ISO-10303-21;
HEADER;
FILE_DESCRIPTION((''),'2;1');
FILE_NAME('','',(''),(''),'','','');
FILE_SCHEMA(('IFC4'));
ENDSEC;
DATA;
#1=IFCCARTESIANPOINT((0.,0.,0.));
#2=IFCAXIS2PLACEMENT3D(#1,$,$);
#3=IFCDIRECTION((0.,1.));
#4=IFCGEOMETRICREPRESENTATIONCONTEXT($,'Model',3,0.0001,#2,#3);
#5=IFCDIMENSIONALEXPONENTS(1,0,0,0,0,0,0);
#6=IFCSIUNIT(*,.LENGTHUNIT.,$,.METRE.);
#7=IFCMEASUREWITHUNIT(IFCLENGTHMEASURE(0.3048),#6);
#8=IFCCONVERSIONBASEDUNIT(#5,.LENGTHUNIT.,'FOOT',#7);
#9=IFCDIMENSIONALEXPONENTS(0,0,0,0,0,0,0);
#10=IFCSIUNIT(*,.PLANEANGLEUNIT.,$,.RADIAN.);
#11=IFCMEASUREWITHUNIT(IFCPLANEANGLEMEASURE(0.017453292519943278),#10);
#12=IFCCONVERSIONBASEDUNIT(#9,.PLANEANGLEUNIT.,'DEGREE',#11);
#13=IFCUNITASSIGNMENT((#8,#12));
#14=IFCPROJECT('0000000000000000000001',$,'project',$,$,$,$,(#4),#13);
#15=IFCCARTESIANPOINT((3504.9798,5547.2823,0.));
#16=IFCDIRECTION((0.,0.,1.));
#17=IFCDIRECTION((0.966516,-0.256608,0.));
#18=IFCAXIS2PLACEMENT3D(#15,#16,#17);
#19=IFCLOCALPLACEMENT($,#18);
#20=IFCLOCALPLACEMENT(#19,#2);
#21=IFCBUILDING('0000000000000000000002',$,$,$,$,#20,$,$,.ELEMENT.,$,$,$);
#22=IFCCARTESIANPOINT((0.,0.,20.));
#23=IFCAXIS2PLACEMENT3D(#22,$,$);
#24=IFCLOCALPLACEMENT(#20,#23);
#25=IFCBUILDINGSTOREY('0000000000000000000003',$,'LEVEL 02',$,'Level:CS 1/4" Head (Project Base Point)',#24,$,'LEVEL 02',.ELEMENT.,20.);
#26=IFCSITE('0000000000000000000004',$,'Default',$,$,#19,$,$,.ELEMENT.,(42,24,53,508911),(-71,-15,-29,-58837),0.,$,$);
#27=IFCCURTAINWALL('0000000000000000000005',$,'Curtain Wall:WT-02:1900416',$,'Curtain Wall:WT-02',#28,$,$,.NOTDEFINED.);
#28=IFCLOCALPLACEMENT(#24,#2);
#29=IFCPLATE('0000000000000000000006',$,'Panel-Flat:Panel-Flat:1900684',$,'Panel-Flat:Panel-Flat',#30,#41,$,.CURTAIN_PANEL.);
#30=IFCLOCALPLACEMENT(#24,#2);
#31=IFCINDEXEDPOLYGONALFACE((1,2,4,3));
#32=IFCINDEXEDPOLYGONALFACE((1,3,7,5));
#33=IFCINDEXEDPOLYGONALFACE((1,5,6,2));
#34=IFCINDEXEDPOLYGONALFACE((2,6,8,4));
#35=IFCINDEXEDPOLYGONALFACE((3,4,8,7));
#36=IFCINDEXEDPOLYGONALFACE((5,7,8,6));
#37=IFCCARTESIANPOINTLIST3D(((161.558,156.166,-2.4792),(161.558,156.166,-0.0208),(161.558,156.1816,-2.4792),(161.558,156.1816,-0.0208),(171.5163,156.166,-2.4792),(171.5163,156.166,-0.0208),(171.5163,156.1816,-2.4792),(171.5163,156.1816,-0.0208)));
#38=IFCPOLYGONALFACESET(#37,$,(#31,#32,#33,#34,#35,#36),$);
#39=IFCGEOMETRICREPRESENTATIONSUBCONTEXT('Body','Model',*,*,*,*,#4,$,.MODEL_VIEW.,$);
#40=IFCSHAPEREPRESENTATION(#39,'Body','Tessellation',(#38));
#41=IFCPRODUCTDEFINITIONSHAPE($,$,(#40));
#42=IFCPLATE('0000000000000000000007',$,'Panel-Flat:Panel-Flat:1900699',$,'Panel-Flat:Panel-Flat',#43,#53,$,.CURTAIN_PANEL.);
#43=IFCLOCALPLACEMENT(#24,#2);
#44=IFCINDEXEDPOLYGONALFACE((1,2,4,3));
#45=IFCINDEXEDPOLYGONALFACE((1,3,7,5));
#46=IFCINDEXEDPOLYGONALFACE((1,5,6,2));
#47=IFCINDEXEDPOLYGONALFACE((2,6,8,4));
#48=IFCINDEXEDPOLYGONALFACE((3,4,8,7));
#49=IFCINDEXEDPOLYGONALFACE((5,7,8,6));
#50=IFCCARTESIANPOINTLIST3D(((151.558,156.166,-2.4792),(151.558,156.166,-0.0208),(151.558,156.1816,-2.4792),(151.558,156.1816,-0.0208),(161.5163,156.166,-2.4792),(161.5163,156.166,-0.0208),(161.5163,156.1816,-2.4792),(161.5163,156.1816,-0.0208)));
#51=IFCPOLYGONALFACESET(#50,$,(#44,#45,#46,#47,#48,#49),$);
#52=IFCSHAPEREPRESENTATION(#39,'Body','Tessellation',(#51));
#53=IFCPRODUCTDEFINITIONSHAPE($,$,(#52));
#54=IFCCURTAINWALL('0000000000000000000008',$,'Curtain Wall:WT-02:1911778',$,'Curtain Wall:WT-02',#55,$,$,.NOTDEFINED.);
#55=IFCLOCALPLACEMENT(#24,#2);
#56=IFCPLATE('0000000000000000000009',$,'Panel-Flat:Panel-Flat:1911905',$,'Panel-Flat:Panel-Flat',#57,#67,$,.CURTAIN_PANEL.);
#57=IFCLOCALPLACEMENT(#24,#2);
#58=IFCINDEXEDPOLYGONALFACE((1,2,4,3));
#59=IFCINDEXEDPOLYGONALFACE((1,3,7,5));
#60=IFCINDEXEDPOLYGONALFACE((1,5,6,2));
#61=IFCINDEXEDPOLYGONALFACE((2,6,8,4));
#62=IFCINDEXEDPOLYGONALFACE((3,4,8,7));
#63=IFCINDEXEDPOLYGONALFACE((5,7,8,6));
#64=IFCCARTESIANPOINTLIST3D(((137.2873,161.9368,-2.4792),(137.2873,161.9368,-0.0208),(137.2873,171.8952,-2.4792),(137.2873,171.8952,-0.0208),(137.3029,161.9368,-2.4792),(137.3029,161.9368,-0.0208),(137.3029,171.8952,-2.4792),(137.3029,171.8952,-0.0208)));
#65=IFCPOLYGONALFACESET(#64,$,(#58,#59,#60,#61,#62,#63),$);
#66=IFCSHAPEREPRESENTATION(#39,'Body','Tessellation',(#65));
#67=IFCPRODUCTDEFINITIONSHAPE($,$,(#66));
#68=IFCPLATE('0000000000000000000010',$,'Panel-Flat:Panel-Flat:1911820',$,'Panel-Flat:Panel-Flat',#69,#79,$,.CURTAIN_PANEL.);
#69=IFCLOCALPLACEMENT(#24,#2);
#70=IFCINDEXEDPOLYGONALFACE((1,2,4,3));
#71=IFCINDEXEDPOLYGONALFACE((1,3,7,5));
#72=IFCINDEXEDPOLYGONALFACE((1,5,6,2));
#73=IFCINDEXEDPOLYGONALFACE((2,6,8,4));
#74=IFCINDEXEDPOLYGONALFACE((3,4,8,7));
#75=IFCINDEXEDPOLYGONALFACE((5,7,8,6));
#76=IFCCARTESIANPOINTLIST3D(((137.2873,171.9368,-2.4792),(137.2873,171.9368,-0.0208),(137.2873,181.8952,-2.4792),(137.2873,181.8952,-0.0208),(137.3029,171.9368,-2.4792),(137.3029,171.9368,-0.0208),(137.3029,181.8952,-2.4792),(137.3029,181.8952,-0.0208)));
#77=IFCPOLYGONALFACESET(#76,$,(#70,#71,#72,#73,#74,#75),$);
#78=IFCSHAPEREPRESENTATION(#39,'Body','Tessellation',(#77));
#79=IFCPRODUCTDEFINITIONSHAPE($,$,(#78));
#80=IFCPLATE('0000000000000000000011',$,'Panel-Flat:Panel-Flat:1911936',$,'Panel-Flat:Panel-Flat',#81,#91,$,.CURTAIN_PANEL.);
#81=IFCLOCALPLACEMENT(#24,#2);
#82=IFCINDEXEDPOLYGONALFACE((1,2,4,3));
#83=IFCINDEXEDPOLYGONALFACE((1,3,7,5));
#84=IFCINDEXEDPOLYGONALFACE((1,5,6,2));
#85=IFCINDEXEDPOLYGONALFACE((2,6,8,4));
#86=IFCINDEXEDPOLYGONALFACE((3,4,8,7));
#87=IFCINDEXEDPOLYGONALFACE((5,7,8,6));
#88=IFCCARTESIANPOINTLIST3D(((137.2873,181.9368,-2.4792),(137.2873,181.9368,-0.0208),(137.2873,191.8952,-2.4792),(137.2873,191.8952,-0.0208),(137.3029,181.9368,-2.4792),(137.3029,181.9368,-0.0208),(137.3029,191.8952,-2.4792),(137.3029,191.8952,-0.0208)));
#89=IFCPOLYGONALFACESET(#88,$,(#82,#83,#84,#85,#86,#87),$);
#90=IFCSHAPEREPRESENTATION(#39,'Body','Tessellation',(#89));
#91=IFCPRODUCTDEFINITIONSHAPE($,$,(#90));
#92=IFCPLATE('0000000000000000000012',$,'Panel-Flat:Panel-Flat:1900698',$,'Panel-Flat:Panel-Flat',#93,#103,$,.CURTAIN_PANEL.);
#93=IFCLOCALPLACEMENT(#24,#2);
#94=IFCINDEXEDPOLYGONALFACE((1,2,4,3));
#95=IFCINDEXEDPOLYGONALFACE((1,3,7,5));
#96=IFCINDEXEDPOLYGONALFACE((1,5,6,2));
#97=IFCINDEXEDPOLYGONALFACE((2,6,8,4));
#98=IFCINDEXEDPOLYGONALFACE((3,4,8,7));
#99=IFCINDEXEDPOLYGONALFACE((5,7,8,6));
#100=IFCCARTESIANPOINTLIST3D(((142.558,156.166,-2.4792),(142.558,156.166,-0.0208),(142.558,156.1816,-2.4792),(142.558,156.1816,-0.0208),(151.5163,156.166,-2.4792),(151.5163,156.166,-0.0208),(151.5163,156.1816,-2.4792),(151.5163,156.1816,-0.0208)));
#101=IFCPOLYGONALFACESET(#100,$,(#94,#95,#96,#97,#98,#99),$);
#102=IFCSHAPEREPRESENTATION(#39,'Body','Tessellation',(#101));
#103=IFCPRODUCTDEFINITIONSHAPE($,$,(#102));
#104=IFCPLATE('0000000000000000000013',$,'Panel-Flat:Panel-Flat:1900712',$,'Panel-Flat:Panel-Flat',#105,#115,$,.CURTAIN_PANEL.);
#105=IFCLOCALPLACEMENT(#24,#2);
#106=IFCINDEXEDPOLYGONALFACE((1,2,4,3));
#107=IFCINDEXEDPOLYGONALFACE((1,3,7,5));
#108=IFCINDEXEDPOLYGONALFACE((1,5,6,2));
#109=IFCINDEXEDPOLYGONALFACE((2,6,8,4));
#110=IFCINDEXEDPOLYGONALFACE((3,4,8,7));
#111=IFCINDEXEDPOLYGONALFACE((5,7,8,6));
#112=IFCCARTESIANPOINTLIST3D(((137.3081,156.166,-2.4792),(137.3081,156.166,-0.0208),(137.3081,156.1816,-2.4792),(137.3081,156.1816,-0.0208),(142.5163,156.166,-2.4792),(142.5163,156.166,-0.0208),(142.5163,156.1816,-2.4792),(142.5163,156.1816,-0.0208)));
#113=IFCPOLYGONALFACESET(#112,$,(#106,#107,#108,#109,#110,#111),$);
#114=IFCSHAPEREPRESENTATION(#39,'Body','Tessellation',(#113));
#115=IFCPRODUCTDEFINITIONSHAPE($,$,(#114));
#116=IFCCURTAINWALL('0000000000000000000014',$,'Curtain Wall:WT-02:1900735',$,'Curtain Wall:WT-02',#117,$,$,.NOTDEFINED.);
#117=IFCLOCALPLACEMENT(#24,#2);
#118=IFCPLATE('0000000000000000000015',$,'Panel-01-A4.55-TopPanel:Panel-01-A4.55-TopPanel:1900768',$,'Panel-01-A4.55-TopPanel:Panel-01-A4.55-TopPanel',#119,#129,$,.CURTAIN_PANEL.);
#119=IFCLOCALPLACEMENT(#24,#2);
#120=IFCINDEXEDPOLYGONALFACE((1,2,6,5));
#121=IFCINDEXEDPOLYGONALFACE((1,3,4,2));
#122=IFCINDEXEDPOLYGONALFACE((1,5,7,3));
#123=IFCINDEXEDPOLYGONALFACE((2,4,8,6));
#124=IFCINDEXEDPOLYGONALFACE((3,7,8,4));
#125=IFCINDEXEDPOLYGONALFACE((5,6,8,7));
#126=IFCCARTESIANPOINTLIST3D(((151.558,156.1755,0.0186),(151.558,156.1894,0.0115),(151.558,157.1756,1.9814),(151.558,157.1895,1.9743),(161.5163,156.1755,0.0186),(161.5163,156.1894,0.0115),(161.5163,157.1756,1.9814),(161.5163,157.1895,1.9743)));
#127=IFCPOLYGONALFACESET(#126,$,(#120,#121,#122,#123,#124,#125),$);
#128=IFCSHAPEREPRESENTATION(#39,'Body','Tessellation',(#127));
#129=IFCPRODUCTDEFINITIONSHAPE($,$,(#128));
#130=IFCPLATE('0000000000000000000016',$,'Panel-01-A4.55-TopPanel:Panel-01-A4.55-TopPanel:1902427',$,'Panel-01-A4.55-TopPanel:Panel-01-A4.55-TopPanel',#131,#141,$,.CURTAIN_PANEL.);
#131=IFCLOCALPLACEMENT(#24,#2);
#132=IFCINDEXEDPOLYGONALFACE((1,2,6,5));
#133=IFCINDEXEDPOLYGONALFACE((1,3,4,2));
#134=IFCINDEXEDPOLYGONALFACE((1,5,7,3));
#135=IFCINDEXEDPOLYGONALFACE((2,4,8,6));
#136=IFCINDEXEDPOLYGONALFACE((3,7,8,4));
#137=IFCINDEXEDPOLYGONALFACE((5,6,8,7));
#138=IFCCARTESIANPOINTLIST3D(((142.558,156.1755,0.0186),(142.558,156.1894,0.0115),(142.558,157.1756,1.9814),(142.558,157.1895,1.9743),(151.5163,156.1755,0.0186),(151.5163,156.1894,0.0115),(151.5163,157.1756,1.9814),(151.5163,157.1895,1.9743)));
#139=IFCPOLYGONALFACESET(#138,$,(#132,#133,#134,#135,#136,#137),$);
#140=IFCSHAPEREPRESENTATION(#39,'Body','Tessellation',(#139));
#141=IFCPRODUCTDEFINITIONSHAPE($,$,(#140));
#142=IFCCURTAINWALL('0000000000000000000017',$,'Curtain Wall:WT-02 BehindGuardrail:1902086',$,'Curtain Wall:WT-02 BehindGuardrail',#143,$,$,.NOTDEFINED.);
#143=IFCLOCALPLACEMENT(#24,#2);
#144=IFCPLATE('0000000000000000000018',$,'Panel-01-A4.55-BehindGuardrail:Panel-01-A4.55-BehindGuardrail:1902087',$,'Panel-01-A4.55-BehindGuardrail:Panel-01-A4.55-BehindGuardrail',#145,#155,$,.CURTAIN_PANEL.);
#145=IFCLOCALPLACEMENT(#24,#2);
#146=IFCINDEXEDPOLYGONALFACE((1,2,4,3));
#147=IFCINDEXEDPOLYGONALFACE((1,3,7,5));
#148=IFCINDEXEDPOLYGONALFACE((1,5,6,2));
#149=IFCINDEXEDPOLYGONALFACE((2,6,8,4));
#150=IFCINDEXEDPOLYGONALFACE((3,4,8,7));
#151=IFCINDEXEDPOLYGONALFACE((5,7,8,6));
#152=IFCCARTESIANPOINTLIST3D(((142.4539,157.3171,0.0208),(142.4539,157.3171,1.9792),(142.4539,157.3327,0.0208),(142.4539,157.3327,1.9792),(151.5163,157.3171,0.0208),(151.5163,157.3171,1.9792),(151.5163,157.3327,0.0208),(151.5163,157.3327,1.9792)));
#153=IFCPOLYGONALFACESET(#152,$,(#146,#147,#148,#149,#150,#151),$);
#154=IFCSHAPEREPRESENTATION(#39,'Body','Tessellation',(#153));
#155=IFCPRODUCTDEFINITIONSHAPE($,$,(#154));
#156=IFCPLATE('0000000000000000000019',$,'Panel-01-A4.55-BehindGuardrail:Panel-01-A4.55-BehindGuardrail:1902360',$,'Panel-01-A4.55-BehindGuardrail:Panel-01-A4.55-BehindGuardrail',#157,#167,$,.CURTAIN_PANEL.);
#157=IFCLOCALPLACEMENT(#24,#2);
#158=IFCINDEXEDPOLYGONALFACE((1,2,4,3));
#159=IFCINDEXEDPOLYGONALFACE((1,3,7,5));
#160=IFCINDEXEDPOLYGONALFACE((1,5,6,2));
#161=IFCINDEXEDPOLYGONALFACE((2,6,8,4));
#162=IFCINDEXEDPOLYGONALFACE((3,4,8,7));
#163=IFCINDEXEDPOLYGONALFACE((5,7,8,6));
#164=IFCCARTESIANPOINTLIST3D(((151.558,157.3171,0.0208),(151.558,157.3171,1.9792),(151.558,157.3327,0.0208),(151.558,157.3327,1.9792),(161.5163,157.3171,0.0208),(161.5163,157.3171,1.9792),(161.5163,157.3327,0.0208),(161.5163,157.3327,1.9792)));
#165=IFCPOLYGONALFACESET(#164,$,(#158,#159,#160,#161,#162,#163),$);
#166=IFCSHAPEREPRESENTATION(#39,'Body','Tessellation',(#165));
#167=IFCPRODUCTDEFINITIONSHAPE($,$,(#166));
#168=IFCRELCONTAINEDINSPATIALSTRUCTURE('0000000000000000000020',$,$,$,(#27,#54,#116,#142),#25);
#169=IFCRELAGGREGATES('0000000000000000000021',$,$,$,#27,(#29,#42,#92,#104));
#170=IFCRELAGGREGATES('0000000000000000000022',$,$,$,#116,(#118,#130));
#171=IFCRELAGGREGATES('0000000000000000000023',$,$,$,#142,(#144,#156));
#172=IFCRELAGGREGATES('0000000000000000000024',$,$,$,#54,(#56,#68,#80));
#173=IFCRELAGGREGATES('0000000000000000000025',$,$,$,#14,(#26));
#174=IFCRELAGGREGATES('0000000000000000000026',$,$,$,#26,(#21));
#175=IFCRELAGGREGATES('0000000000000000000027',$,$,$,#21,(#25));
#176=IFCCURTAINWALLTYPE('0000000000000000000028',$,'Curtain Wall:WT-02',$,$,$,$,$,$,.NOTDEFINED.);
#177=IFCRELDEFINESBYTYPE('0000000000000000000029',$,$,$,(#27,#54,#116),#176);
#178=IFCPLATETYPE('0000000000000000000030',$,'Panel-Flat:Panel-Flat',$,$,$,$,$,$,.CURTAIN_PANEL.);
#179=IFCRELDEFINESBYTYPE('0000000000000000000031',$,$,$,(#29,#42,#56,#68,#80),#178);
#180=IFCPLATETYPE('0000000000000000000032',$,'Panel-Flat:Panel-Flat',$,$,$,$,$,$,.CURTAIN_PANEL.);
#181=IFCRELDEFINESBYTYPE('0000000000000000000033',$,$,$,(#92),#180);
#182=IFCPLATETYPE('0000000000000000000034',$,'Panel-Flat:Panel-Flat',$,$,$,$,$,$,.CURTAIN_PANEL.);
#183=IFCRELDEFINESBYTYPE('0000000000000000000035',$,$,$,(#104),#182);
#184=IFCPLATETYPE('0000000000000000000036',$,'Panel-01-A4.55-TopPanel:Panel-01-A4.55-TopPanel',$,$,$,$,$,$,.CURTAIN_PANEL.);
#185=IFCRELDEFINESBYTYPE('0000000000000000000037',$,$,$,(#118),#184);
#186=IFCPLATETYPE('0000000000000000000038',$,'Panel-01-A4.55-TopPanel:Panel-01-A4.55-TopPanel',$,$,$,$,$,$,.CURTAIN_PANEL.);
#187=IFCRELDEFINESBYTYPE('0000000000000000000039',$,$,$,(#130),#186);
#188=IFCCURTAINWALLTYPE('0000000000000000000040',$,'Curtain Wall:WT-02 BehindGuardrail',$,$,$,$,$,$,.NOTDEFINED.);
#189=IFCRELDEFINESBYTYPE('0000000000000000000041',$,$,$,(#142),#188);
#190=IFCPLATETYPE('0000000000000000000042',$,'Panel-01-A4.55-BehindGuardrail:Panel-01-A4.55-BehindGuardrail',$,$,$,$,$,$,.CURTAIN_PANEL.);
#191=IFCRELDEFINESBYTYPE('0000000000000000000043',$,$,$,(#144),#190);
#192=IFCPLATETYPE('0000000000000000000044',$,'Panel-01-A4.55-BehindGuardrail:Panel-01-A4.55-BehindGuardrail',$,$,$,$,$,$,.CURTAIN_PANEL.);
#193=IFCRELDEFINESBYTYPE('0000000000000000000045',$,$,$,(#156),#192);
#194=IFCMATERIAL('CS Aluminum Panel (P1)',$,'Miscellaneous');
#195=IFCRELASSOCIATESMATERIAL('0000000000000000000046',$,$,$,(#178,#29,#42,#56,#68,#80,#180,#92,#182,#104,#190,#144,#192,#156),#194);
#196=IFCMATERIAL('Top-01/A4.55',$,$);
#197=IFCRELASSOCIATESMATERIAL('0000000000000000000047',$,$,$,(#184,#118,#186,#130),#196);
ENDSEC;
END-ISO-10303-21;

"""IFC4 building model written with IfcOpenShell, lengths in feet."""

from ifc_helpers import new_model, entity, si_unit, converted_unit, direction, frame, origin, place, context, subcontext, project, spatial, indexed_curve, outline, extrude, source, transform, mapped, material, type_object, type_shapes, element, aggregate, save


model = new_model("IFC4")

# Units and contexts
model_context = context("Model", 3, precision=0.0001, world=origin(), true_north=direction((0.0, 1.0)))
body_context = subcontext(model_context, "Body", "Model", "MODEL_VIEW")
ifc_project = project(units=[converted_unit("LENGTHUNIT", "FOOT", entity("IfcLengthMeasure", 0.3048), si_unit("LENGTHUNIT", "METRE"), dimensions=[1, 0, 0, 0, 0, 0, 0]), converted_unit("PLANEANGLEUNIT", "DEGREE", entity("IfcPlaneAngleMeasure", 0.017453292519943278), si_unit("PLANEANGLEUNIT", "RADIAN"), dimensions=[0, 0, 0, 0, 0, 0, 0])], contexts=[model_context])

# Site, building, storey
site_placement = place(None, frame((3504.9798, 5547.2823, 0.0), z_axis=(0.0, 0.0, 1.0), x_axis=(0.966516, -0.256608, 0.0)))
site = spatial("IfcSite", under=ifc_project, at=site_placement, Name="Default", CompositionType="ELEMENT", RefLatitude=(42, 24, 53, 508911), RefLongitude=(-71, -15, -29, -58837), RefElevation=0.0)
building_placement = place(site_placement, origin())
building = spatial("IfcBuilding", under=site, at=building_placement, CompositionType="ELEMENT")
storey_placement = place(building_placement, frame((0.0, 0.0, 20.0)))
storey = spatial("IfcBuildingStorey", under=building, at=storey_placement, Name="LEVEL 02", ObjectType="Level:CS 1/4\" Head (Project Base Point)", LongName="LEVEL 02", CompositionType="ELEMENT", Elevation=20.0)

# Curtain walls, plates
curtain_wall_type_1 = type_object("IfcCurtainWallType", Name="Curtain Wall:WT-02", PredefinedType="NOTDEFINED")
curtain_wall_1_placement = place(storey_placement, frame((0.0, 0.0, -20.0)))
curtain_wall_1 = element("IfcCurtainWall", 1, at=curtain_wall_1_placement, inside=storey, type_object=curtain_wall_type_1, Name="Curtain Wall:WT-02:1900416", ObjectType="Curtain Wall:WT-02", PredefinedType="NOTDEFINED")
ifc_material_1 = material(Name="CS Aluminum Panel (P1)", Category="Miscellaneous")
plate_type_1 = type_object("IfcPlateType", Name="Panel-Flat:Panel-Flat", PredefinedType="CURTAIN_PANEL", material=ifc_material_1)
shared_shape_1 = source(origin(), body_context, "Body", "SweptSolid", [
    extrude(outline(indexed_curve([(-0.0078, -4.9792), (0.0078, -4.9792), (0.0078, 4.9792), (-0.0078, 4.9792), (-0.0078, -4.9792)], self_intersect=False)), frame((0.0, -0.0078, 0.0208), z_axis=(0.0, 0.0, 1.0), x_axis=(0.0, -1.0, 0.0)), (0.0, 0.0, 1.0), 2.4583),
])
type_shapes(plate_type_1, [shared_shape_1])
plate_1_placement = place(curtain_wall_1_placement, frame((166.5372, 156.166, 17.5), z_axis=(0.0, 0.0, 1.0), x_axis=(-1.0, 0.0, 0.0)))
plate_1 = element("IfcPlate", 2, at=plate_1_placement, type_object=plate_type_1, material=ifc_material_1, Name="Panel-Flat:Panel-Flat:1900684", ObjectType="Panel-Flat:Panel-Flat", PredefinedType="CURTAIN_PANEL", context=body_context, shape_type="MappedRepresentation", body=[
    mapped(shared_shape_1, transform((0.0, 0.0, 0.0), scale=1.0)),
])
plate_2_placement = place(curtain_wall_1_placement, frame((156.5372, 156.166, 17.5), z_axis=(0.0, 0.0, 1.0), x_axis=(-1.0, 0.0, 0.0)))
plate_2 = element("IfcPlate", 3, at=plate_2_placement, type_object=plate_type_1, material=ifc_material_1, Name="Panel-Flat:Panel-Flat:1900699", ObjectType="Panel-Flat:Panel-Flat", PredefinedType="CURTAIN_PANEL", context=body_context, shape_type="MappedRepresentation", body=[
    mapped(shared_shape_1, transform((0.0, 0.0, 0.0), scale=1.0)),
])
curtain_wall_2_placement = place(storey_placement, frame((0.0, 0.0, -20.0)))
curtain_wall_2 = element("IfcCurtainWall", 4, at=curtain_wall_2_placement, inside=storey, type_object=curtain_wall_type_1, Name="Curtain Wall:WT-02:1911778", ObjectType="Curtain Wall:WT-02", PredefinedType="NOTDEFINED")
plate_3_placement = place(curtain_wall_2_placement, frame((137.2873, 166.916, 17.5), z_axis=(0.0, 0.0, 1.0), x_axis=(0.0, 1.0, 0.0)))
plate_3 = element("IfcPlate", 5, at=plate_3_placement, type_object=plate_type_1, material=ifc_material_1, Name="Panel-Flat:Panel-Flat:1911905", ObjectType="Panel-Flat:Panel-Flat", PredefinedType="CURTAIN_PANEL", context=body_context, shape_type="MappedRepresentation", body=[
    mapped(shared_shape_1, transform((0.0, 0.0, 0.0), scale=1.0)),
])
plate_4_placement = place(curtain_wall_2_placement, frame((137.2873, 176.916, 17.5), z_axis=(0.0, 0.0, 1.0), x_axis=(0.0, 1.0, 0.0)))
plate_4 = element("IfcPlate", 6, at=plate_4_placement, type_object=plate_type_1, material=ifc_material_1, Name="Panel-Flat:Panel-Flat:1911820", ObjectType="Panel-Flat:Panel-Flat", PredefinedType="CURTAIN_PANEL", context=body_context, shape_type="MappedRepresentation", body=[
    mapped(shared_shape_1, transform((0.0, 0.0, 0.0), scale=1.0)),
])
plate_5_placement = place(curtain_wall_2_placement, frame((137.2873, 186.916, 17.5), z_axis=(0.0, 0.0, 1.0), x_axis=(0.0, 1.0, 0.0)))
plate_5 = element("IfcPlate", 7, at=plate_5_placement, type_object=plate_type_1, material=ifc_material_1, Name="Panel-Flat:Panel-Flat:1911936", ObjectType="Panel-Flat:Panel-Flat", PredefinedType="CURTAIN_PANEL", context=body_context, shape_type="MappedRepresentation", body=[
    mapped(shared_shape_1, transform((0.0, 0.0, 0.0), scale=1.0)),
])

# Plates
plate_type_2 = type_object("IfcPlateType", Name="Panel-Flat:Panel-Flat", PredefinedType="CURTAIN_PANEL", material=ifc_material_1)
shared_shape_2 = source(origin(), body_context, "Body", "SweptSolid", [
    extrude(outline(indexed_curve([(-0.0078, -4.4792), (0.0078, -4.4792), (0.0078, 4.4792), (-0.0078, 4.4792), (-0.0078, -4.4792)], self_intersect=False)), frame((0.0, -0.0078, 0.0208), z_axis=(0.0, 0.0, 1.0), x_axis=(0.0, -1.0, 0.0)), (0.0, 0.0, 1.0), 2.4583),
])
type_shapes(plate_type_2, [shared_shape_2])
plate_6_placement = place(curtain_wall_1_placement, frame((147.0372, 156.166, 17.5), z_axis=(0.0, 0.0, 1.0), x_axis=(-1.0, 0.0, 0.0)))
plate_6 = element("IfcPlate", 8, at=plate_6_placement, type_object=plate_type_2, material=ifc_material_1, Name="Panel-Flat:Panel-Flat:1900698", ObjectType="Panel-Flat:Panel-Flat", PredefinedType="CURTAIN_PANEL", context=body_context, shape_type="MappedRepresentation", body=[
    mapped(shared_shape_2, transform((0.0, 0.0, 0.0), scale=1.0)),
])
plate_type_3 = type_object("IfcPlateType", Name="Panel-Flat:Panel-Flat", PredefinedType="CURTAIN_PANEL", material=ifc_material_1)
shared_shape_3 = source(origin(), body_context, "Body", "SweptSolid", [
    extrude(outline(indexed_curve([(-0.0078, -2.6041), (0.0078, -2.6041), (0.0078, 2.6041), (-0.0078, 2.6041), (-0.0078, -2.6041)], self_intersect=False)), frame((0.0, -0.0078, 0.0208), z_axis=(0.0, 0.0, 1.0), x_axis=(0.0, -1.0, 0.0)), (0.0, 0.0, 1.0), 2.4583),
])
type_shapes(plate_type_3, [shared_shape_3])
plate_7_placement = place(curtain_wall_1_placement, frame((139.9122, 156.166, 17.5), z_axis=(0.0, 0.0, 1.0), x_axis=(-1.0, 0.0, 0.0)))
plate_7 = element("IfcPlate", 9, at=plate_7_placement, type_object=plate_type_3, material=ifc_material_1, Name="Panel-Flat:Panel-Flat:1900712", ObjectType="Panel-Flat:Panel-Flat", PredefinedType="CURTAIN_PANEL", context=body_context, shape_type="MappedRepresentation", body=[
    mapped(shared_shape_3, transform((0.0, 0.0, 0.0), scale=1.0)),
])
aggregate(curtain_wall_1, [plate_1, plate_2, plate_6, plate_7])

# Curtain walls, plates
curtain_wall_3_placement = place(storey_placement, frame((0.0, 0.0, -20.0)))
curtain_wall_3 = element("IfcCurtainWall", 10, at=curtain_wall_3_placement, inside=storey, type_object=curtain_wall_type_1, Name="Curtain Wall:WT-02:1900735", ObjectType="Curtain Wall:WT-02", PredefinedType="NOTDEFINED")
ifc_material_2 = material(Name="Top-01/A4.55")
plate_type_4 = type_object("IfcPlateType", Name="Panel-01-A4.55-TopPanel:Panel-01-A4.55-TopPanel", PredefinedType="CURTAIN_PANEL", material=ifc_material_2)
shared_shape_4 = source(origin(), body_context, "Body", "SweptSolid", [
    extrude(outline(indexed_curve([(-0.0078, -4.9792), (0.0078, -4.9792), (0.0078, 4.9792), (-0.0078, 4.9792), (-0.0078, -4.9792)], self_intersect=False)), frame((0.0, -0.0078, 0.0208), z_axis=(0.0, 0.0, 1.0), x_axis=(0.0, -1.0, 0.0)), (0.0, 0.0, 1.0), 2.203),
])
type_shapes(plate_type_4, [shared_shape_4])
plate_8_placement = place(curtain_wall_3_placement, frame((156.5372, 156.166, 20.0), z_axis=(0.0, 0.45399, 0.891007), x_axis=(-1.0, 0.0, 0.0)))
plate_8 = element("IfcPlate", 11, at=plate_8_placement, type_object=plate_type_4, material=ifc_material_2, Name="Panel-01-A4.55-TopPanel:Panel-01-A4.55-TopPanel:1900768", ObjectType="Panel-01-A4.55-TopPanel:Panel-01-A4.55-TopPanel", PredefinedType="CURTAIN_PANEL", context=body_context, shape_type="MappedRepresentation", body=[
    mapped(shared_shape_4, transform((0.0, 0.0, 0.0), scale=1.0)),
])
plate_type_5 = type_object("IfcPlateType", Name="Panel-01-A4.55-TopPanel:Panel-01-A4.55-TopPanel", PredefinedType="CURTAIN_PANEL", material=ifc_material_2)
shared_shape_5 = source(origin(), body_context, "Body", "SweptSolid", [
    extrude(outline(indexed_curve([(-0.0078, -4.4792), (0.0078, -4.4792), (0.0078, 4.4792), (-0.0078, 4.4792), (-0.0078, -4.4792)], self_intersect=False)), frame((0.0, -0.0078, 0.0208), z_axis=(0.0, 0.0, 1.0), x_axis=(0.0, -1.0, 0.0)), (0.0, 0.0, 1.0), 2.203),
])
type_shapes(plate_type_5, [shared_shape_5])
plate_9_placement = place(curtain_wall_3_placement, frame((147.0372, 156.166, 20.0), z_axis=(0.0, 0.45399, 0.891007), x_axis=(-1.0, 0.0, 0.0)))
plate_9 = element("IfcPlate", 12, at=plate_9_placement, type_object=plate_type_5, material=ifc_material_2, Name="Panel-01-A4.55-TopPanel:Panel-01-A4.55-TopPanel:1902427", ObjectType="Panel-01-A4.55-TopPanel:Panel-01-A4.55-TopPanel", PredefinedType="CURTAIN_PANEL", context=body_context, shape_type="MappedRepresentation", body=[
    mapped(shared_shape_5, transform((0.0, 0.0, 0.0), scale=1.0)),
])
aggregate(curtain_wall_3, [plate_8, plate_9])
curtain_wall_type_2 = type_object("IfcCurtainWallType", Name="Curtain Wall:WT-02 BehindGuardrail", PredefinedType="NOTDEFINED")
curtain_wall_4_placement = place(storey_placement, frame((0.0, 0.0, -20.0)))
curtain_wall_4 = element("IfcCurtainWall", 13, at=curtain_wall_4_placement, inside=storey, type_object=curtain_wall_type_2, Name="Curtain Wall:WT-02 BehindGuardrail:1902086", ObjectType="Curtain Wall:WT-02 BehindGuardrail", PredefinedType="NOTDEFINED")
plate_type_6 = type_object("IfcPlateType", Name="Panel-01-A4.55-BehindGuardrail:Panel-01-A4.55-BehindGuardrail", PredefinedType="CURTAIN_PANEL", material=ifc_material_1)
shared_shape_6 = source(origin(), body_context, "Body", "SweptSolid", [
    extrude(outline(indexed_curve([(-0.0078, -4.5312), (0.0078, -4.5312), (0.0078, 4.5312), (-0.0078, 4.5312), (-0.0078, -4.5312)], self_intersect=False)), frame((0.0, -0.0078, 0.0208), z_axis=(0.0, 0.0, 1.0), x_axis=(0.0, -1.0, 0.0)), (0.0, 0.0, 1.0), 1.9583),
])
type_shapes(plate_type_6, [shared_shape_6])
plate_10_placement = place(curtain_wall_4_placement, frame((146.9851, 157.3327, 20.0)))
plate_10 = element("IfcPlate", 14, at=plate_10_placement, type_object=plate_type_6, material=ifc_material_1, Name="Panel-01-A4.55-BehindGuardrail:Panel-01-A4.55-BehindGuardrail:1902087", ObjectType="Panel-01-A4.55-BehindGuardrail:Panel-01-A4.55-BehindGuardrail", PredefinedType="CURTAIN_PANEL", context=body_context, shape_type="MappedRepresentation", body=[
    mapped(shared_shape_6, transform((0.0, 0.0, 0.0), scale=1.0)),
])
plate_type_7 = type_object("IfcPlateType", Name="Panel-01-A4.55-BehindGuardrail:Panel-01-A4.55-BehindGuardrail", PredefinedType="CURTAIN_PANEL", material=ifc_material_1)
shared_shape_7 = source(origin(), body_context, "Body", "SweptSolid", [
    extrude(outline(indexed_curve([(-0.0078, -4.9792), (0.0078, -4.9792), (0.0078, 4.9792), (-0.0078, 4.9792), (-0.0078, -4.9792)], self_intersect=False)), frame((0.0, -0.0078, 0.0208), z_axis=(0.0, 0.0, 1.0), x_axis=(0.0, -1.0, 0.0)), (0.0, 0.0, 1.0), 1.9583),
])
type_shapes(plate_type_7, [shared_shape_7])
plate_11_placement = place(curtain_wall_4_placement, frame((156.5372, 157.3327, 20.0)))
plate_11 = element("IfcPlate", 15, at=plate_11_placement, type_object=plate_type_7, material=ifc_material_1, Name="Panel-01-A4.55-BehindGuardrail:Panel-01-A4.55-BehindGuardrail:1902360", ObjectType="Panel-01-A4.55-BehindGuardrail:Panel-01-A4.55-BehindGuardrail", PredefinedType="CURTAIN_PANEL", context=body_context, shape_type="MappedRepresentation", body=[
    mapped(shared_shape_7, transform((0.0, 0.0, 0.0), scale=1.0)),
])
aggregate(curtain_wall_4, [plate_10, plate_11])

aggregate(curtain_wall_2, [plate_3, plate_4, plate_5])

save(model, "model.ifc")
